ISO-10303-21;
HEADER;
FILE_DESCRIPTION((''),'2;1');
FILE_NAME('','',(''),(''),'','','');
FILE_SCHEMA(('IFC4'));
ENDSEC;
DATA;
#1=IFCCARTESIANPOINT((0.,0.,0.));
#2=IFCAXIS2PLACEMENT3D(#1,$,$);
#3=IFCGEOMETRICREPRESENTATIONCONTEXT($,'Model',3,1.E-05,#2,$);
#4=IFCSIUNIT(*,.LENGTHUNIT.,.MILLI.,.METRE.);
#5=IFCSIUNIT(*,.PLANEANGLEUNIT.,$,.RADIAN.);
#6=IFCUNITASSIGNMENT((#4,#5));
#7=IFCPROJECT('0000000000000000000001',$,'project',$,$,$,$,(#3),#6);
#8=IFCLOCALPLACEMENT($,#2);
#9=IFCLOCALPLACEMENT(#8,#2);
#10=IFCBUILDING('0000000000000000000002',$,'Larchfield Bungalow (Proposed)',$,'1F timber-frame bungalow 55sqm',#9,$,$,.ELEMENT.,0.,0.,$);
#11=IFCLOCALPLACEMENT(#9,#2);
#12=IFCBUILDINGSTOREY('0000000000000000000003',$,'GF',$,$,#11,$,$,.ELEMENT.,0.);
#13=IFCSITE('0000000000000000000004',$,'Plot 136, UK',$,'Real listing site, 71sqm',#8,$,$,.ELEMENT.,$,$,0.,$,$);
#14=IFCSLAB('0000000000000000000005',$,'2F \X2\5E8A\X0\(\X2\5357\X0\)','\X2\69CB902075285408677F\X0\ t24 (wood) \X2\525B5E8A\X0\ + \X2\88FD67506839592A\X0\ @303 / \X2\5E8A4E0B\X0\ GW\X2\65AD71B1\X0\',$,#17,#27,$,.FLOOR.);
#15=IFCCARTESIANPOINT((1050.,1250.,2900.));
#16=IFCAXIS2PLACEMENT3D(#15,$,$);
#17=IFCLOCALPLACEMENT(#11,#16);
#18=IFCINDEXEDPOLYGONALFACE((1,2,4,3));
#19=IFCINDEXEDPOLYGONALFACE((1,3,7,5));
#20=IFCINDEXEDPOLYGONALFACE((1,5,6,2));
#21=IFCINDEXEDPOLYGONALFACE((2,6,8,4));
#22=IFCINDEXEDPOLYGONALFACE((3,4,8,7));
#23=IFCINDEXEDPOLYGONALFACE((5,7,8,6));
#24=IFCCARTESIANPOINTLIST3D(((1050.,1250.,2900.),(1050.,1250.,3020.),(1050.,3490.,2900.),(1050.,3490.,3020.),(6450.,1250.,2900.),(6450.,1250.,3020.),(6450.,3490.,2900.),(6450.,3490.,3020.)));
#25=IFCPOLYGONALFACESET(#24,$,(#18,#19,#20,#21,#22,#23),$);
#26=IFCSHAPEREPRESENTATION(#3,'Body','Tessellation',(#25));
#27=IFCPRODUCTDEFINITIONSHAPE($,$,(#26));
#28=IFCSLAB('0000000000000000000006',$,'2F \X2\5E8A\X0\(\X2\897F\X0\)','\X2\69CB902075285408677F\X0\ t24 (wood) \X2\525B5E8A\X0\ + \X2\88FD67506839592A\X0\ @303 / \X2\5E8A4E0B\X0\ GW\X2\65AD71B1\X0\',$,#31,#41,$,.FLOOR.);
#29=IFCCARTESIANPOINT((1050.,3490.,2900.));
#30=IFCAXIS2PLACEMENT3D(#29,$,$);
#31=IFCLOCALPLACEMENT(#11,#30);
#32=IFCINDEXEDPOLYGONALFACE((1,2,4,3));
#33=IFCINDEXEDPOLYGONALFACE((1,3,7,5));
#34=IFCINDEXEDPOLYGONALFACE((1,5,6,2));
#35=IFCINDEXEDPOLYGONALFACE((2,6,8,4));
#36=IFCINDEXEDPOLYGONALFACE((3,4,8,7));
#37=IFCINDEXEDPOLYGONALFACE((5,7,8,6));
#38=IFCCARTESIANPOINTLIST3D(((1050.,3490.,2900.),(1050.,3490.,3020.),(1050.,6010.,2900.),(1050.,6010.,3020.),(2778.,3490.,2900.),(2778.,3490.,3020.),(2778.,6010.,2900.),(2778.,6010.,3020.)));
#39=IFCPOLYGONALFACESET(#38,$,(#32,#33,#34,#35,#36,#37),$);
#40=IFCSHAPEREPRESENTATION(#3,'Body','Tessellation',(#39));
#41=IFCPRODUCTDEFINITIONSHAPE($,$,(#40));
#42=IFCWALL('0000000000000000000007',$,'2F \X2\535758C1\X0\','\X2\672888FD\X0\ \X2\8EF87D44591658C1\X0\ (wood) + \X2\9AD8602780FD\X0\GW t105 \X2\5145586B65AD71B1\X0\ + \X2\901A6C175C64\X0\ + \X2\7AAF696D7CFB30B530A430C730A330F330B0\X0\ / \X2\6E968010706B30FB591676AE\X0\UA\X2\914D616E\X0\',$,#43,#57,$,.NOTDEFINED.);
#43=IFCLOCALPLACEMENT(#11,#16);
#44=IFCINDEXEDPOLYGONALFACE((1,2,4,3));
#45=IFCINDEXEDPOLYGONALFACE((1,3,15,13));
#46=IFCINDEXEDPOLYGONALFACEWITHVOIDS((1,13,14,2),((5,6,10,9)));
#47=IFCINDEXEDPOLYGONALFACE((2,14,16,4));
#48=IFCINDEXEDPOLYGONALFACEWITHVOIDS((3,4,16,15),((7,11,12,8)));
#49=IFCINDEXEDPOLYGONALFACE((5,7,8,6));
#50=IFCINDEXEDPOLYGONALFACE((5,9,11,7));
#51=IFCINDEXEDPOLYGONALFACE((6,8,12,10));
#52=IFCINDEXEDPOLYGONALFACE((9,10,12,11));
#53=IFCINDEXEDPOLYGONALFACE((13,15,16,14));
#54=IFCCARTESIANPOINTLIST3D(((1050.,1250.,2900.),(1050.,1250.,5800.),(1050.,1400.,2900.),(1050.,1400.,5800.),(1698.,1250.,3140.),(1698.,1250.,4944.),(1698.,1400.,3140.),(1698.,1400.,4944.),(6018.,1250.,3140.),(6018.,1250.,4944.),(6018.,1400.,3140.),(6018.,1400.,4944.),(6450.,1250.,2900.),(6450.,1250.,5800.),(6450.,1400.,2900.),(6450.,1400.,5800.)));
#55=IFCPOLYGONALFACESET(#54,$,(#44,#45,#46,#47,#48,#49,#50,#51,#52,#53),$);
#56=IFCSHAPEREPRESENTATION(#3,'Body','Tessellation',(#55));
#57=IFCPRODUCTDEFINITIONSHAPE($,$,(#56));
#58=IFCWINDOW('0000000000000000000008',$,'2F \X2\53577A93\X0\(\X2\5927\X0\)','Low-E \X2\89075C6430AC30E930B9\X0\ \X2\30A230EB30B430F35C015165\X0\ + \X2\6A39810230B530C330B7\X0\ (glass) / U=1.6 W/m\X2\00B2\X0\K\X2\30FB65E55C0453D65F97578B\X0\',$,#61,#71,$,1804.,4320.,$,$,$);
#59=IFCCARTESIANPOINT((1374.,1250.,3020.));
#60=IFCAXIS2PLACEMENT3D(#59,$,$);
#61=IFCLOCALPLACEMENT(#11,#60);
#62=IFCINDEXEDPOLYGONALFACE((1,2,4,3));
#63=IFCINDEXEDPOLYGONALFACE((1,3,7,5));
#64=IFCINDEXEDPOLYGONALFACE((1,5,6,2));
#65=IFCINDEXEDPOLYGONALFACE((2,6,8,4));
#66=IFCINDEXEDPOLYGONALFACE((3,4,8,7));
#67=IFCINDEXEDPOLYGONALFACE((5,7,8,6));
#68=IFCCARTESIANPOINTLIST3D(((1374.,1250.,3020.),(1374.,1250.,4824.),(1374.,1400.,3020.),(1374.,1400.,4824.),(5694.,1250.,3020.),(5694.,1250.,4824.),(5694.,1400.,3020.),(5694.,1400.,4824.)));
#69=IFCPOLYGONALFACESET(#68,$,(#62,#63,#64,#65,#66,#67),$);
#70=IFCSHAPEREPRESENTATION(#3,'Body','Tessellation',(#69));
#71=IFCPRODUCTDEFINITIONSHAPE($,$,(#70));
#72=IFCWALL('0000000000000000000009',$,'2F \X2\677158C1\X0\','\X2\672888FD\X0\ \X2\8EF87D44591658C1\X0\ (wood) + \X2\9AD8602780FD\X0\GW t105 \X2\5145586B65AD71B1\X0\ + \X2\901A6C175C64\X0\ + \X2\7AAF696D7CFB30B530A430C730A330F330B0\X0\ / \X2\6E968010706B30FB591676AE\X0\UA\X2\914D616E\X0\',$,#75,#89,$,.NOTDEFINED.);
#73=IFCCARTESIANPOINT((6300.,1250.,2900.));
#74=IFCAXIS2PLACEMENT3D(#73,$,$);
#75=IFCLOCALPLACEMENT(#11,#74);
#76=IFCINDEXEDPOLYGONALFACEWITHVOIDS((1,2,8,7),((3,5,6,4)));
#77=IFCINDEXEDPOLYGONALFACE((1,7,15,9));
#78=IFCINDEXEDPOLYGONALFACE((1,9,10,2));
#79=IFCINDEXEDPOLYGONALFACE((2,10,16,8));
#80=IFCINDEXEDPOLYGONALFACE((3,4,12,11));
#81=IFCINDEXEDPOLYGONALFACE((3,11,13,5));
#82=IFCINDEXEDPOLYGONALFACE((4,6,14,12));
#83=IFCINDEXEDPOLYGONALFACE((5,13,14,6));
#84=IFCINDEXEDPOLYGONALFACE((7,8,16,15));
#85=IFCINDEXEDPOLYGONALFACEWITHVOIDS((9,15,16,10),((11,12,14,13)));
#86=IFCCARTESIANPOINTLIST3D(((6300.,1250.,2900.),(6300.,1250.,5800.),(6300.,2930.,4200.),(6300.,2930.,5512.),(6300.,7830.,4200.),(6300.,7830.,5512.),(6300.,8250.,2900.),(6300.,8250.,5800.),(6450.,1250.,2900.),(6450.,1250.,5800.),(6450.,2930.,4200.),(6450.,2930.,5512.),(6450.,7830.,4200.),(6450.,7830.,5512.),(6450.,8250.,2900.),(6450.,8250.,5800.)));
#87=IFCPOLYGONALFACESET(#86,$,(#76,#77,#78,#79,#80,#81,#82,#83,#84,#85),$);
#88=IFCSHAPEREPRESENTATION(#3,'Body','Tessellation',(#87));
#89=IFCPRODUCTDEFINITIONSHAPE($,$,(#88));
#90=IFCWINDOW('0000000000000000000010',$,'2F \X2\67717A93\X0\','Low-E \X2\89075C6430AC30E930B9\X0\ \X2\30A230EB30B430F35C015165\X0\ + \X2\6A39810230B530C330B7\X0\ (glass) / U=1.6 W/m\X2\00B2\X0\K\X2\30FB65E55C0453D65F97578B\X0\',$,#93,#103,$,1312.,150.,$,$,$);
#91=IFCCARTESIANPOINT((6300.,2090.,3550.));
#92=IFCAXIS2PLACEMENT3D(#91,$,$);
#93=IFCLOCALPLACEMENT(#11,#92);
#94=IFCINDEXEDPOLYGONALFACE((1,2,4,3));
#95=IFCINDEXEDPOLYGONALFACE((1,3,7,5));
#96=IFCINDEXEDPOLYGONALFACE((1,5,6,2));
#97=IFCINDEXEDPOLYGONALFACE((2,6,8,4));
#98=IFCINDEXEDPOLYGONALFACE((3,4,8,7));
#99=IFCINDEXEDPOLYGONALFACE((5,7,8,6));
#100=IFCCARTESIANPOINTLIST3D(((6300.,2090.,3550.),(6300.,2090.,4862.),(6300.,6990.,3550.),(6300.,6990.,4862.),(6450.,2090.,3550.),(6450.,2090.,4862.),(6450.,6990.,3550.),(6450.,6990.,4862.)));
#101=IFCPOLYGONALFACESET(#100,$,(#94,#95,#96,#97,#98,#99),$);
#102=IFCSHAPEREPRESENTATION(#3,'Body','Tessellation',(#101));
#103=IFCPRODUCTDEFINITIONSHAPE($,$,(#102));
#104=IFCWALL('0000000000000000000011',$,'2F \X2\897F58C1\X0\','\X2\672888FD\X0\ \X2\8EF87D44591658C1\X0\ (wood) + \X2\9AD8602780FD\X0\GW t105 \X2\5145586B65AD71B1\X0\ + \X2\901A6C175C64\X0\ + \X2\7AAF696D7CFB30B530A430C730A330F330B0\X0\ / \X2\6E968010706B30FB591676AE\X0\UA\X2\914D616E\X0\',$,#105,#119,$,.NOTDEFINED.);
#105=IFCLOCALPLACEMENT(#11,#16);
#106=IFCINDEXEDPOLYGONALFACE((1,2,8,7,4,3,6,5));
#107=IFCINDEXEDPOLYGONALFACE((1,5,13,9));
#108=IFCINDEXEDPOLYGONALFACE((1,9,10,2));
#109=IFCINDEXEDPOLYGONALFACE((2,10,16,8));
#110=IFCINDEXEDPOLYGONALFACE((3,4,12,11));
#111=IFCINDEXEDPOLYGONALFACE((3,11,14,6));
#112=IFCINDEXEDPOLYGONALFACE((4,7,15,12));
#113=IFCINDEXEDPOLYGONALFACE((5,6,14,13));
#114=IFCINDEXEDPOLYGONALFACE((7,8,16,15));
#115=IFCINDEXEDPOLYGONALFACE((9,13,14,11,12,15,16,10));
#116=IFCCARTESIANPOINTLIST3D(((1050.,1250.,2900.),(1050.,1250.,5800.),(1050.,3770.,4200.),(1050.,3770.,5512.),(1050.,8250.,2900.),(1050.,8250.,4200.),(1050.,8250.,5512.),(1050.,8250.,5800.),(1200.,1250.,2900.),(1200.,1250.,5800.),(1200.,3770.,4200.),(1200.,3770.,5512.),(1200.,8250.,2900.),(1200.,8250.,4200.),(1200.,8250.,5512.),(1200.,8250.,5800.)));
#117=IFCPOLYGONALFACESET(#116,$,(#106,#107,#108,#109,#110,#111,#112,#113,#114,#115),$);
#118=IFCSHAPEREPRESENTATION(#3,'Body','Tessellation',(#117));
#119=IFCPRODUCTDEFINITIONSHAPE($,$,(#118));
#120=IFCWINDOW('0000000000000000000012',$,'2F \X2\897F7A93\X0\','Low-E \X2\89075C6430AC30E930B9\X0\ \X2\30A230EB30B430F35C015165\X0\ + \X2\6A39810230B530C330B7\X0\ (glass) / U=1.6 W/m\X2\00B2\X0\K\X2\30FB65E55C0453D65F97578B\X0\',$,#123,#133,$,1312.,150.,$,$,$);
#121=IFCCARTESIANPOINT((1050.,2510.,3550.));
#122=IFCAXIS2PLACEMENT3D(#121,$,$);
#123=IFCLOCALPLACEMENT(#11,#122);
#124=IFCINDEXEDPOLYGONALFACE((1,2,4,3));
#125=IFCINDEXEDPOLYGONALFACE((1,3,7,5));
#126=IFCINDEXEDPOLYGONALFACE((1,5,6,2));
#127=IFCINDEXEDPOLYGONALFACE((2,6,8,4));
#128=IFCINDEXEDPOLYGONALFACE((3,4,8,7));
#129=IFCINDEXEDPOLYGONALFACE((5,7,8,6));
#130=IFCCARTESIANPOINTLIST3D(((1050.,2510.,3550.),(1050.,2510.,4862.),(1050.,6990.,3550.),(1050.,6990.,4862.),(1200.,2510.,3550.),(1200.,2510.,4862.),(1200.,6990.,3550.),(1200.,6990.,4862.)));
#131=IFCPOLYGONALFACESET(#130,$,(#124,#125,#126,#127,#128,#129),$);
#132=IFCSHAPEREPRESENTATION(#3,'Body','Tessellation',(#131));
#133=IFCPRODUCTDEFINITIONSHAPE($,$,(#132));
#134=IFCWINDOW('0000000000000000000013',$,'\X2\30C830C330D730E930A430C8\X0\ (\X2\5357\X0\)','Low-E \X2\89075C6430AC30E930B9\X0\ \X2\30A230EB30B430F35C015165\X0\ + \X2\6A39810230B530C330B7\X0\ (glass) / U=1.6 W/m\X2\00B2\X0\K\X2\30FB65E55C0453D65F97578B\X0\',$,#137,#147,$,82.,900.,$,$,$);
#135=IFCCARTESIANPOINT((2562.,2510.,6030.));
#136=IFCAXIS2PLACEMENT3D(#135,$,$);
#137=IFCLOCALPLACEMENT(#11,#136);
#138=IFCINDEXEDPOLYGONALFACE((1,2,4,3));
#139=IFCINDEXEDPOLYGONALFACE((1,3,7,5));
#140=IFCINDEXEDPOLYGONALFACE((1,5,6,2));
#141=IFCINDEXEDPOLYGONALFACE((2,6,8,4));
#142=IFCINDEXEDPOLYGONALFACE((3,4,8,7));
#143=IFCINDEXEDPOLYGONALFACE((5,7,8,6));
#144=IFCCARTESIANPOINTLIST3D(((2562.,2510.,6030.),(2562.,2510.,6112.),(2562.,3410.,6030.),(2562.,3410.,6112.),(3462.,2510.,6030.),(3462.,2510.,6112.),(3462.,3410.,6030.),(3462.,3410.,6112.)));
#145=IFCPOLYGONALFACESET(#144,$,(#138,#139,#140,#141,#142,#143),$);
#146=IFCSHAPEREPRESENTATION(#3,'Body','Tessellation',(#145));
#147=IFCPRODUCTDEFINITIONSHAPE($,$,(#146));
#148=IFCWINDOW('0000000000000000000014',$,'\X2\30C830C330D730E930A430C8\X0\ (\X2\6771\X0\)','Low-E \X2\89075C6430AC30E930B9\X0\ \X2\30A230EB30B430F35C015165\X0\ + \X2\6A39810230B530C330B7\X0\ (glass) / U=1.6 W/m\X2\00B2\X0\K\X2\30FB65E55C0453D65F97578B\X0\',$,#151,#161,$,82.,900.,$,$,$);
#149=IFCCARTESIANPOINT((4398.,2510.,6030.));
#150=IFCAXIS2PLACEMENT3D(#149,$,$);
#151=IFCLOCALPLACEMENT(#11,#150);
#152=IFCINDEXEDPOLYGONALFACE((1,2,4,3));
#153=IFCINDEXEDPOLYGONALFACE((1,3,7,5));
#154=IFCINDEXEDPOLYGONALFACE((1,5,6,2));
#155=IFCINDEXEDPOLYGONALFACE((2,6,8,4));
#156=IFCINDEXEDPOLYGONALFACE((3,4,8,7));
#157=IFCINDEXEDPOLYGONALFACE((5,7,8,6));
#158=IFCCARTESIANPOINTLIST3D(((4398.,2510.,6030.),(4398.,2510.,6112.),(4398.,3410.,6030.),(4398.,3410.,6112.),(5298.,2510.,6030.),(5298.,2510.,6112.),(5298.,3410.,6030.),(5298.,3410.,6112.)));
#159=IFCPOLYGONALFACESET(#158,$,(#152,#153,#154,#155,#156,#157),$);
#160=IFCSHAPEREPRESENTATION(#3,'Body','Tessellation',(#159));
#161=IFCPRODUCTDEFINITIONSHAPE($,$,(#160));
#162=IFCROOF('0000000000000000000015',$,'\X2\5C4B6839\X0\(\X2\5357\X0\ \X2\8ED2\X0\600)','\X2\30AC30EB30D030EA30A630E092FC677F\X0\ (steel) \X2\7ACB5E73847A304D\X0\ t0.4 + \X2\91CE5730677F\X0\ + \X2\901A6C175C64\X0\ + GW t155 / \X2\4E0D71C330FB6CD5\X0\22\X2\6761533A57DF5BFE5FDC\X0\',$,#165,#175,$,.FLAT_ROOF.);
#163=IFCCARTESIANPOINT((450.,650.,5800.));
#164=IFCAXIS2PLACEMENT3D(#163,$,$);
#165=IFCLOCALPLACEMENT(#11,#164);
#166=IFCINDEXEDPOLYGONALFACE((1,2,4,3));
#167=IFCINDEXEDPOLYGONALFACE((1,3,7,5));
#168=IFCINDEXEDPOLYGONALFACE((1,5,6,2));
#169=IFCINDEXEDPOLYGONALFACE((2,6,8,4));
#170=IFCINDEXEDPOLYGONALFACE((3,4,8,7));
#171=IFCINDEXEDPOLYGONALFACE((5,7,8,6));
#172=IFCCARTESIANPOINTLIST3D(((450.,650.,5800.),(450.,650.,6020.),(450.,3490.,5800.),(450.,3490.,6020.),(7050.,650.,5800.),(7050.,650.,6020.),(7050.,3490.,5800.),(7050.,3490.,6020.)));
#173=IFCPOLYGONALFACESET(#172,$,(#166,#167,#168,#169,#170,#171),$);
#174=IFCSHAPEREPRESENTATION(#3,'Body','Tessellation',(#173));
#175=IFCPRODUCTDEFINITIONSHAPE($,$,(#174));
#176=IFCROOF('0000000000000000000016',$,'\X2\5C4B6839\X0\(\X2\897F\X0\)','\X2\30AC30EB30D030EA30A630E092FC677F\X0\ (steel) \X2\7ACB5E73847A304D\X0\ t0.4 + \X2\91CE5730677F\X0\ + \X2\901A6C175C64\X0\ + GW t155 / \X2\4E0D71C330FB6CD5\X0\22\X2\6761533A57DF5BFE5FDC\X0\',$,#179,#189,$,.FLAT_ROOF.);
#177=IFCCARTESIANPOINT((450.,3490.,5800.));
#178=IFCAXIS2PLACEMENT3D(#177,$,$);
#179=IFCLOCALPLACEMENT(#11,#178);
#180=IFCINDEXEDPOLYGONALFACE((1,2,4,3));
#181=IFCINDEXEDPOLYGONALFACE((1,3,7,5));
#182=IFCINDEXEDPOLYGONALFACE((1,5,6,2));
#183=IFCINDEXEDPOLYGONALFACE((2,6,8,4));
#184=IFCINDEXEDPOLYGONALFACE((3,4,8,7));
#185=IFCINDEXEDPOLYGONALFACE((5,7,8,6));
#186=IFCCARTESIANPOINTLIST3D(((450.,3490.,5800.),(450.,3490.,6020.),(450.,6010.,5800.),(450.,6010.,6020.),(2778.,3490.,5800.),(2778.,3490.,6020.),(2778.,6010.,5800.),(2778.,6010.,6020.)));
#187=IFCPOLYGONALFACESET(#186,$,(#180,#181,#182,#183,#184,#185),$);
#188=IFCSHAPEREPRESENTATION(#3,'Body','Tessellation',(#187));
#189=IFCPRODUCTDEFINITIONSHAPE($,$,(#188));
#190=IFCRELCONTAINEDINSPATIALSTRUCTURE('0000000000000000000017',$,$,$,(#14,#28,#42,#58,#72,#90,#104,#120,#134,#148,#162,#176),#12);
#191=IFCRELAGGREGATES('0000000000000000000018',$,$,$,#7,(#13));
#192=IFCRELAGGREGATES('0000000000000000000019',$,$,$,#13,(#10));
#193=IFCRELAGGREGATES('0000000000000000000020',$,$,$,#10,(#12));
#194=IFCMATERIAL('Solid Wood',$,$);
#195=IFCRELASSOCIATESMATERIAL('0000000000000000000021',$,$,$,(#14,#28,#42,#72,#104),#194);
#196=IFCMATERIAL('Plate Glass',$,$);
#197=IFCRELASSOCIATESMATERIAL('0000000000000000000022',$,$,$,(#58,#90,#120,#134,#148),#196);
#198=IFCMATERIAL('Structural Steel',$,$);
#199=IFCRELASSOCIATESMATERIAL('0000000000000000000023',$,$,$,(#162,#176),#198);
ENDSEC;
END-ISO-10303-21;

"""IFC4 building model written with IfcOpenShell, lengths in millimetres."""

from ifc_helpers import new_model, si_unit, frame, frame_2d, origin, place, context, project, spatial, rectangle, extrude, material, element, fill, save


model = new_model("IFC4")

# Units and contexts
model_context = context("Model", 3, precision=1e-05, world=origin())
ifc_project = project(units=[si_unit("LENGTHUNIT", "METRE", prefix="MILLI"), si_unit("PLANEANGLEUNIT", "RADIAN")], contexts=[model_context])

# Site, building, storey
site_placement = place(None, origin())
site = spatial("IfcSite", under=ifc_project, at=site_placement, Name="Plot 136, UK", ObjectType="Real listing site, 71sqm", CompositionType="ELEMENT", RefElevation=0.0)
building_placement = place(site_placement, origin())
building = spatial("IfcBuilding", under=site, at=building_placement, Name="Larchfield Bungalow (Proposed)", ObjectType="1F timber-frame bungalow 55sqm", CompositionType="ELEMENT", ElevationOfRefHeight=0.0, ElevationOfTerrain=0.0)
storey_placement = place(building_placement, origin())
storey = spatial("IfcBuildingStorey", under=building, at=storey_placement, Name="GF", CompositionType="ELEMENT", Elevation=0.0)

# Slabs
ifc_material_1 = material(Name="Solid Wood")
slab_1_placement = place(storey_placement, frame((1050.0, 1250.0, 2900.0)))
element("IfcSlab", 1, at=slab_1_placement, inside=storey, material=ifc_material_1, Name="2F 床(南)", Description="構造用合板 t24 (wood) 剛床 + 製材根太 @303 / 床下 GW断熱", PredefinedType="FLOOR", context=model_context, shape_type="SweptSolid", body=[
    extrude(rectangle(XDim=5400.0, YDim=2240.0, at=frame_2d((2700.0, 1120.0))), frame((1050.0, 1250.0, 2900.0)), (0.0, 0.0, 1.0), 120.0),
])
slab_2_placement = place(storey_placement, frame((1050.0, 3490.0, 2900.0)))
element("IfcSlab", 2, at=slab_2_placement, inside=storey, material=ifc_material_1, Name="2F 床(西)", Description="構造用合板 t24 (wood) 剛床 + 製材根太 @303 / 床下 GW断熱", PredefinedType="FLOOR", context=model_context, shape_type="SweptSolid", body=[
    extrude(rectangle(XDim=1728.0, YDim=2520.0, at=frame_2d((864.0, 1260.0))), frame((1050.0, 3490.0, 2900.0)), (0.0, 0.0, 1.0), 120.0),
])

# Walls, openings, windows
wall_1_placement = place(storey_placement, frame((1050.0, 1250.0, 2900.0)))
wall_1 = element("IfcWall", 3, at=wall_1_placement, inside=storey, material=ifc_material_1, Name="2F 南壁", Description="木製 軸組外壁 (wood) + 高性能GW t105 充填断熱 + 通気層 + 窯業系サイディング / 準耐火・外皮UA配慮", PredefinedType="NOTDEFINED", context=model_context, shape_type="SweptSolid", body=[
    extrude(rectangle(XDim=5400.0, YDim=150.0, at=frame_2d((2700.0, 75.0))), frame((1050.0, 1250.0, 2900.0)), (0.0, 0.0, 1.0), 2900.0),
])
opening_1_placement = place(storey_placement, frame((1374.0, 1250.0, 3020.0)))
opening_1 = element("IfcOpeningElement", 4, at=opening_1_placement, cuts=wall_1, PredefinedType="NOTDEFINED", context=model_context, shape_type="SweptSolid", body=[
    extrude(rectangle(XDim=4320.0, YDim=150.0, at=frame_2d((2160.0, 75.0))), frame((1374.0, 1250.0, 3020.0)), (0.0, 0.0, 1.0), 1804.0),
])
ifc_material_2 = material(Name="Plate Glass")
window_1_placement = place(storey_placement, frame((1374.0, 1250.0, 3020.0)))
window_1 = element("IfcWindow", 5, at=window_1_placement, inside=storey, material=ifc_material_2, Name="2F 南窓(大)", Description="Low-E 複層ガラス アルゴン封入 + 樹脂サッシ (glass) / U=1.6 W/m²K・日射取得型", OverallHeight=1804.0, OverallWidth=4320.0, context=model_context, shape_type="SweptSolid", body=[
    extrude(rectangle(XDim=4320.0, YDim=150.0, at=frame_2d((2160.0, 75.0))), frame((1374.0, 1250.0, 3020.0)), (0.0, 0.0, 1.0), 1804.0),
])
fill(opening_1, window_1)
wall_2_placement = place(storey_placement, frame((6300.0, 1250.0, 2900.0)))
wall_2 = element("IfcWall", 6, at=wall_2_placement, inside=storey, material=ifc_material_1, Name="2F 東壁", Description="木製 軸組外壁 (wood) + 高性能GW t105 充填断熱 + 通気層 + 窯業系サイディング / 準耐火・外皮UA配慮", PredefinedType="NOTDEFINED", context=model_context, shape_type="SweptSolid", body=[
    extrude(rectangle(XDim=150.0, YDim=7000.0, at=frame_2d((75.0, 3500.0))), frame((6300.0, 1250.0, 2900.0)), (0.0, 0.0, 1.0), 2900.0),
])
opening_2_placement = place(storey_placement, frame((6300.0, 2090.0, 3550.0)))
opening_2 = element("IfcOpeningElement", 7, at=opening_2_placement, cuts=wall_2, PredefinedType="NOTDEFINED", context=model_context, shape_type="SweptSolid", body=[
    extrude(rectangle(XDim=150.0, YDim=4900.0, at=frame_2d((75.0, 2450.0))), frame((6300.0, 2090.0, 3550.0)), (0.0, 0.0, 1.0), 1312.0),
])
window_2_placement = place(storey_placement, frame((6300.0, 2090.0, 3550.0)))
window_2 = element("IfcWindow", 8, at=window_2_placement, inside=storey, material=ifc_material_2, Name="2F 東窓", Description="Low-E 複層ガラス アルゴン封入 + 樹脂サッシ (glass) / U=1.6 W/m²K・日射取得型", OverallHeight=1312.0, OverallWidth=150.0, context=model_context, shape_type="SweptSolid", body=[
    extrude(rectangle(XDim=150.0, YDim=4900.0, at=frame_2d((75.0, 2450.0))), frame((6300.0, 2090.0, 3550.0)), (0.0, 0.0, 1.0), 1312.0),
])
fill(opening_2, window_2)
wall_3_placement = place(storey_placement, frame((1050.0, 1250.0, 2900.0)))
wall_3 = element("IfcWall", 9, at=wall_3_placement, inside=storey, material=ifc_material_1, Name="2F 西壁", Description="木製 軸組外壁 (wood) + 高性能GW t105 充填断熱 + 通気層 + 窯業系サイディング / 準耐火・外皮UA配慮", PredefinedType="NOTDEFINED", context=model_context, shape_type="SweptSolid", body=[
    extrude(rectangle(XDim=150.0, YDim=7000.0, at=frame_2d((75.0, 3500.0))), frame((1050.0, 1250.0, 2900.0)), (0.0, 0.0, 1.0), 2900.0),
])
opening_3_placement = place(storey_placement, frame((1050.0, 2510.0, 3550.0)))
opening_3 = element("IfcOpeningElement", 10, at=opening_3_placement, cuts=wall_3, PredefinedType="NOTDEFINED", context=model_context, shape_type="SweptSolid", body=[
    extrude(rectangle(XDim=150.0, YDim=4480.0, at=frame_2d((75.0, 2240.0))), frame((1050.0, 2510.0, 3550.0)), (0.0, 0.0, 1.0), 1312.0),
])
window_3_placement = place(storey_placement, frame((1050.0, 2510.0, 3550.0)))
window_3 = element("IfcWindow", 11, at=window_3_placement, inside=storey, material=ifc_material_2, Name="2F 西窓", Description="Low-E 複層ガラス アルゴン封入 + 樹脂サッシ (glass) / U=1.6 W/m²K・日射取得型", OverallHeight=1312.0, OverallWidth=150.0, context=model_context, shape_type="SweptSolid", body=[
    extrude(rectangle(XDim=150.0, YDim=4480.0, at=frame_2d((75.0, 2240.0))), frame((1050.0, 2510.0, 3550.0)), (0.0, 0.0, 1.0), 1312.0),
])
fill(opening_3, window_3)

# Windows
window_4_placement = place(storey_placement, frame((2562.0, 2510.0, 6030.0)))
element("IfcWindow", 12, at=window_4_placement, inside=storey, material=ifc_material_2, Name="トップライト (南)", Description="Low-E 複層ガラス アルゴン封入 + 樹脂サッシ (glass) / U=1.6 W/m²K・日射取得型", OverallHeight=82.0, OverallWidth=900.0, context=model_context, shape_type="SweptSolid", body=[
    extrude(rectangle(XDim=900.0, YDim=900.0, at=frame_2d((450.0, 450.0))), frame((2562.0, 2510.0, 6030.0)), (0.0, 0.0, 1.0), 82.0),
])
window_5_placement = place(storey_placement, frame((4398.0, 2510.0, 6030.0)))
element("IfcWindow", 13, at=window_5_placement, inside=storey, material=ifc_material_2, Name="トップライト (東)", Description="Low-E 複層ガラス アルゴン封入 + 樹脂サッシ (glass) / U=1.6 W/m²K・日射取得型", OverallHeight=82.0, OverallWidth=900.0, context=model_context, shape_type="SweptSolid", body=[
    extrude(rectangle(XDim=900.0, YDim=900.0, at=frame_2d((450.0, 450.0))), frame((4398.0, 2510.0, 6030.0)), (0.0, 0.0, 1.0), 82.0),
])

# Roofs
ifc_material_3 = material(Name="Structural Steel")
roof_1_placement = place(storey_placement, frame((450.0, 650.0, 5800.0)))
element("IfcRoof", 14, at=roof_1_placement, inside=storey, material=ifc_material_3, Name="屋根(南 軒600)", Description="ガルバリウム鋼板 (steel) 立平葺き t0.4 + 野地板 + 通気層 + GW t155 / 不燃・法22条区域対応", PredefinedType="FLAT_ROOF", context=model_context, shape_type="SweptSolid", body=[
    extrude(rectangle(XDim=6600.0, YDim=2840.0, at=frame_2d((3300.0, 1420.0))), frame((450.0, 650.0, 5800.0)), (0.0, 0.0, 1.0), 220.0),
])
roof_2_placement = place(storey_placement, frame((450.0, 3490.0, 5800.0)))
element("IfcRoof", 15, at=roof_2_placement, inside=storey, material=ifc_material_3, Name="屋根(西)", Description="ガルバリウム鋼板 (steel) 立平葺き t0.4 + 野地板 + 通気層 + GW t155 / 不燃・法22条区域対応", PredefinedType="FLAT_ROOF", context=model_context, shape_type="SweptSolid", body=[
    extrude(rectangle(XDim=2328.0, YDim=2520.0, at=frame_2d((1164.0, 1260.0))), frame((450.0, 3490.0, 5800.0)), (0.0, 0.0, 1.0), 220.0),
])

save(model, "model.ifc")
